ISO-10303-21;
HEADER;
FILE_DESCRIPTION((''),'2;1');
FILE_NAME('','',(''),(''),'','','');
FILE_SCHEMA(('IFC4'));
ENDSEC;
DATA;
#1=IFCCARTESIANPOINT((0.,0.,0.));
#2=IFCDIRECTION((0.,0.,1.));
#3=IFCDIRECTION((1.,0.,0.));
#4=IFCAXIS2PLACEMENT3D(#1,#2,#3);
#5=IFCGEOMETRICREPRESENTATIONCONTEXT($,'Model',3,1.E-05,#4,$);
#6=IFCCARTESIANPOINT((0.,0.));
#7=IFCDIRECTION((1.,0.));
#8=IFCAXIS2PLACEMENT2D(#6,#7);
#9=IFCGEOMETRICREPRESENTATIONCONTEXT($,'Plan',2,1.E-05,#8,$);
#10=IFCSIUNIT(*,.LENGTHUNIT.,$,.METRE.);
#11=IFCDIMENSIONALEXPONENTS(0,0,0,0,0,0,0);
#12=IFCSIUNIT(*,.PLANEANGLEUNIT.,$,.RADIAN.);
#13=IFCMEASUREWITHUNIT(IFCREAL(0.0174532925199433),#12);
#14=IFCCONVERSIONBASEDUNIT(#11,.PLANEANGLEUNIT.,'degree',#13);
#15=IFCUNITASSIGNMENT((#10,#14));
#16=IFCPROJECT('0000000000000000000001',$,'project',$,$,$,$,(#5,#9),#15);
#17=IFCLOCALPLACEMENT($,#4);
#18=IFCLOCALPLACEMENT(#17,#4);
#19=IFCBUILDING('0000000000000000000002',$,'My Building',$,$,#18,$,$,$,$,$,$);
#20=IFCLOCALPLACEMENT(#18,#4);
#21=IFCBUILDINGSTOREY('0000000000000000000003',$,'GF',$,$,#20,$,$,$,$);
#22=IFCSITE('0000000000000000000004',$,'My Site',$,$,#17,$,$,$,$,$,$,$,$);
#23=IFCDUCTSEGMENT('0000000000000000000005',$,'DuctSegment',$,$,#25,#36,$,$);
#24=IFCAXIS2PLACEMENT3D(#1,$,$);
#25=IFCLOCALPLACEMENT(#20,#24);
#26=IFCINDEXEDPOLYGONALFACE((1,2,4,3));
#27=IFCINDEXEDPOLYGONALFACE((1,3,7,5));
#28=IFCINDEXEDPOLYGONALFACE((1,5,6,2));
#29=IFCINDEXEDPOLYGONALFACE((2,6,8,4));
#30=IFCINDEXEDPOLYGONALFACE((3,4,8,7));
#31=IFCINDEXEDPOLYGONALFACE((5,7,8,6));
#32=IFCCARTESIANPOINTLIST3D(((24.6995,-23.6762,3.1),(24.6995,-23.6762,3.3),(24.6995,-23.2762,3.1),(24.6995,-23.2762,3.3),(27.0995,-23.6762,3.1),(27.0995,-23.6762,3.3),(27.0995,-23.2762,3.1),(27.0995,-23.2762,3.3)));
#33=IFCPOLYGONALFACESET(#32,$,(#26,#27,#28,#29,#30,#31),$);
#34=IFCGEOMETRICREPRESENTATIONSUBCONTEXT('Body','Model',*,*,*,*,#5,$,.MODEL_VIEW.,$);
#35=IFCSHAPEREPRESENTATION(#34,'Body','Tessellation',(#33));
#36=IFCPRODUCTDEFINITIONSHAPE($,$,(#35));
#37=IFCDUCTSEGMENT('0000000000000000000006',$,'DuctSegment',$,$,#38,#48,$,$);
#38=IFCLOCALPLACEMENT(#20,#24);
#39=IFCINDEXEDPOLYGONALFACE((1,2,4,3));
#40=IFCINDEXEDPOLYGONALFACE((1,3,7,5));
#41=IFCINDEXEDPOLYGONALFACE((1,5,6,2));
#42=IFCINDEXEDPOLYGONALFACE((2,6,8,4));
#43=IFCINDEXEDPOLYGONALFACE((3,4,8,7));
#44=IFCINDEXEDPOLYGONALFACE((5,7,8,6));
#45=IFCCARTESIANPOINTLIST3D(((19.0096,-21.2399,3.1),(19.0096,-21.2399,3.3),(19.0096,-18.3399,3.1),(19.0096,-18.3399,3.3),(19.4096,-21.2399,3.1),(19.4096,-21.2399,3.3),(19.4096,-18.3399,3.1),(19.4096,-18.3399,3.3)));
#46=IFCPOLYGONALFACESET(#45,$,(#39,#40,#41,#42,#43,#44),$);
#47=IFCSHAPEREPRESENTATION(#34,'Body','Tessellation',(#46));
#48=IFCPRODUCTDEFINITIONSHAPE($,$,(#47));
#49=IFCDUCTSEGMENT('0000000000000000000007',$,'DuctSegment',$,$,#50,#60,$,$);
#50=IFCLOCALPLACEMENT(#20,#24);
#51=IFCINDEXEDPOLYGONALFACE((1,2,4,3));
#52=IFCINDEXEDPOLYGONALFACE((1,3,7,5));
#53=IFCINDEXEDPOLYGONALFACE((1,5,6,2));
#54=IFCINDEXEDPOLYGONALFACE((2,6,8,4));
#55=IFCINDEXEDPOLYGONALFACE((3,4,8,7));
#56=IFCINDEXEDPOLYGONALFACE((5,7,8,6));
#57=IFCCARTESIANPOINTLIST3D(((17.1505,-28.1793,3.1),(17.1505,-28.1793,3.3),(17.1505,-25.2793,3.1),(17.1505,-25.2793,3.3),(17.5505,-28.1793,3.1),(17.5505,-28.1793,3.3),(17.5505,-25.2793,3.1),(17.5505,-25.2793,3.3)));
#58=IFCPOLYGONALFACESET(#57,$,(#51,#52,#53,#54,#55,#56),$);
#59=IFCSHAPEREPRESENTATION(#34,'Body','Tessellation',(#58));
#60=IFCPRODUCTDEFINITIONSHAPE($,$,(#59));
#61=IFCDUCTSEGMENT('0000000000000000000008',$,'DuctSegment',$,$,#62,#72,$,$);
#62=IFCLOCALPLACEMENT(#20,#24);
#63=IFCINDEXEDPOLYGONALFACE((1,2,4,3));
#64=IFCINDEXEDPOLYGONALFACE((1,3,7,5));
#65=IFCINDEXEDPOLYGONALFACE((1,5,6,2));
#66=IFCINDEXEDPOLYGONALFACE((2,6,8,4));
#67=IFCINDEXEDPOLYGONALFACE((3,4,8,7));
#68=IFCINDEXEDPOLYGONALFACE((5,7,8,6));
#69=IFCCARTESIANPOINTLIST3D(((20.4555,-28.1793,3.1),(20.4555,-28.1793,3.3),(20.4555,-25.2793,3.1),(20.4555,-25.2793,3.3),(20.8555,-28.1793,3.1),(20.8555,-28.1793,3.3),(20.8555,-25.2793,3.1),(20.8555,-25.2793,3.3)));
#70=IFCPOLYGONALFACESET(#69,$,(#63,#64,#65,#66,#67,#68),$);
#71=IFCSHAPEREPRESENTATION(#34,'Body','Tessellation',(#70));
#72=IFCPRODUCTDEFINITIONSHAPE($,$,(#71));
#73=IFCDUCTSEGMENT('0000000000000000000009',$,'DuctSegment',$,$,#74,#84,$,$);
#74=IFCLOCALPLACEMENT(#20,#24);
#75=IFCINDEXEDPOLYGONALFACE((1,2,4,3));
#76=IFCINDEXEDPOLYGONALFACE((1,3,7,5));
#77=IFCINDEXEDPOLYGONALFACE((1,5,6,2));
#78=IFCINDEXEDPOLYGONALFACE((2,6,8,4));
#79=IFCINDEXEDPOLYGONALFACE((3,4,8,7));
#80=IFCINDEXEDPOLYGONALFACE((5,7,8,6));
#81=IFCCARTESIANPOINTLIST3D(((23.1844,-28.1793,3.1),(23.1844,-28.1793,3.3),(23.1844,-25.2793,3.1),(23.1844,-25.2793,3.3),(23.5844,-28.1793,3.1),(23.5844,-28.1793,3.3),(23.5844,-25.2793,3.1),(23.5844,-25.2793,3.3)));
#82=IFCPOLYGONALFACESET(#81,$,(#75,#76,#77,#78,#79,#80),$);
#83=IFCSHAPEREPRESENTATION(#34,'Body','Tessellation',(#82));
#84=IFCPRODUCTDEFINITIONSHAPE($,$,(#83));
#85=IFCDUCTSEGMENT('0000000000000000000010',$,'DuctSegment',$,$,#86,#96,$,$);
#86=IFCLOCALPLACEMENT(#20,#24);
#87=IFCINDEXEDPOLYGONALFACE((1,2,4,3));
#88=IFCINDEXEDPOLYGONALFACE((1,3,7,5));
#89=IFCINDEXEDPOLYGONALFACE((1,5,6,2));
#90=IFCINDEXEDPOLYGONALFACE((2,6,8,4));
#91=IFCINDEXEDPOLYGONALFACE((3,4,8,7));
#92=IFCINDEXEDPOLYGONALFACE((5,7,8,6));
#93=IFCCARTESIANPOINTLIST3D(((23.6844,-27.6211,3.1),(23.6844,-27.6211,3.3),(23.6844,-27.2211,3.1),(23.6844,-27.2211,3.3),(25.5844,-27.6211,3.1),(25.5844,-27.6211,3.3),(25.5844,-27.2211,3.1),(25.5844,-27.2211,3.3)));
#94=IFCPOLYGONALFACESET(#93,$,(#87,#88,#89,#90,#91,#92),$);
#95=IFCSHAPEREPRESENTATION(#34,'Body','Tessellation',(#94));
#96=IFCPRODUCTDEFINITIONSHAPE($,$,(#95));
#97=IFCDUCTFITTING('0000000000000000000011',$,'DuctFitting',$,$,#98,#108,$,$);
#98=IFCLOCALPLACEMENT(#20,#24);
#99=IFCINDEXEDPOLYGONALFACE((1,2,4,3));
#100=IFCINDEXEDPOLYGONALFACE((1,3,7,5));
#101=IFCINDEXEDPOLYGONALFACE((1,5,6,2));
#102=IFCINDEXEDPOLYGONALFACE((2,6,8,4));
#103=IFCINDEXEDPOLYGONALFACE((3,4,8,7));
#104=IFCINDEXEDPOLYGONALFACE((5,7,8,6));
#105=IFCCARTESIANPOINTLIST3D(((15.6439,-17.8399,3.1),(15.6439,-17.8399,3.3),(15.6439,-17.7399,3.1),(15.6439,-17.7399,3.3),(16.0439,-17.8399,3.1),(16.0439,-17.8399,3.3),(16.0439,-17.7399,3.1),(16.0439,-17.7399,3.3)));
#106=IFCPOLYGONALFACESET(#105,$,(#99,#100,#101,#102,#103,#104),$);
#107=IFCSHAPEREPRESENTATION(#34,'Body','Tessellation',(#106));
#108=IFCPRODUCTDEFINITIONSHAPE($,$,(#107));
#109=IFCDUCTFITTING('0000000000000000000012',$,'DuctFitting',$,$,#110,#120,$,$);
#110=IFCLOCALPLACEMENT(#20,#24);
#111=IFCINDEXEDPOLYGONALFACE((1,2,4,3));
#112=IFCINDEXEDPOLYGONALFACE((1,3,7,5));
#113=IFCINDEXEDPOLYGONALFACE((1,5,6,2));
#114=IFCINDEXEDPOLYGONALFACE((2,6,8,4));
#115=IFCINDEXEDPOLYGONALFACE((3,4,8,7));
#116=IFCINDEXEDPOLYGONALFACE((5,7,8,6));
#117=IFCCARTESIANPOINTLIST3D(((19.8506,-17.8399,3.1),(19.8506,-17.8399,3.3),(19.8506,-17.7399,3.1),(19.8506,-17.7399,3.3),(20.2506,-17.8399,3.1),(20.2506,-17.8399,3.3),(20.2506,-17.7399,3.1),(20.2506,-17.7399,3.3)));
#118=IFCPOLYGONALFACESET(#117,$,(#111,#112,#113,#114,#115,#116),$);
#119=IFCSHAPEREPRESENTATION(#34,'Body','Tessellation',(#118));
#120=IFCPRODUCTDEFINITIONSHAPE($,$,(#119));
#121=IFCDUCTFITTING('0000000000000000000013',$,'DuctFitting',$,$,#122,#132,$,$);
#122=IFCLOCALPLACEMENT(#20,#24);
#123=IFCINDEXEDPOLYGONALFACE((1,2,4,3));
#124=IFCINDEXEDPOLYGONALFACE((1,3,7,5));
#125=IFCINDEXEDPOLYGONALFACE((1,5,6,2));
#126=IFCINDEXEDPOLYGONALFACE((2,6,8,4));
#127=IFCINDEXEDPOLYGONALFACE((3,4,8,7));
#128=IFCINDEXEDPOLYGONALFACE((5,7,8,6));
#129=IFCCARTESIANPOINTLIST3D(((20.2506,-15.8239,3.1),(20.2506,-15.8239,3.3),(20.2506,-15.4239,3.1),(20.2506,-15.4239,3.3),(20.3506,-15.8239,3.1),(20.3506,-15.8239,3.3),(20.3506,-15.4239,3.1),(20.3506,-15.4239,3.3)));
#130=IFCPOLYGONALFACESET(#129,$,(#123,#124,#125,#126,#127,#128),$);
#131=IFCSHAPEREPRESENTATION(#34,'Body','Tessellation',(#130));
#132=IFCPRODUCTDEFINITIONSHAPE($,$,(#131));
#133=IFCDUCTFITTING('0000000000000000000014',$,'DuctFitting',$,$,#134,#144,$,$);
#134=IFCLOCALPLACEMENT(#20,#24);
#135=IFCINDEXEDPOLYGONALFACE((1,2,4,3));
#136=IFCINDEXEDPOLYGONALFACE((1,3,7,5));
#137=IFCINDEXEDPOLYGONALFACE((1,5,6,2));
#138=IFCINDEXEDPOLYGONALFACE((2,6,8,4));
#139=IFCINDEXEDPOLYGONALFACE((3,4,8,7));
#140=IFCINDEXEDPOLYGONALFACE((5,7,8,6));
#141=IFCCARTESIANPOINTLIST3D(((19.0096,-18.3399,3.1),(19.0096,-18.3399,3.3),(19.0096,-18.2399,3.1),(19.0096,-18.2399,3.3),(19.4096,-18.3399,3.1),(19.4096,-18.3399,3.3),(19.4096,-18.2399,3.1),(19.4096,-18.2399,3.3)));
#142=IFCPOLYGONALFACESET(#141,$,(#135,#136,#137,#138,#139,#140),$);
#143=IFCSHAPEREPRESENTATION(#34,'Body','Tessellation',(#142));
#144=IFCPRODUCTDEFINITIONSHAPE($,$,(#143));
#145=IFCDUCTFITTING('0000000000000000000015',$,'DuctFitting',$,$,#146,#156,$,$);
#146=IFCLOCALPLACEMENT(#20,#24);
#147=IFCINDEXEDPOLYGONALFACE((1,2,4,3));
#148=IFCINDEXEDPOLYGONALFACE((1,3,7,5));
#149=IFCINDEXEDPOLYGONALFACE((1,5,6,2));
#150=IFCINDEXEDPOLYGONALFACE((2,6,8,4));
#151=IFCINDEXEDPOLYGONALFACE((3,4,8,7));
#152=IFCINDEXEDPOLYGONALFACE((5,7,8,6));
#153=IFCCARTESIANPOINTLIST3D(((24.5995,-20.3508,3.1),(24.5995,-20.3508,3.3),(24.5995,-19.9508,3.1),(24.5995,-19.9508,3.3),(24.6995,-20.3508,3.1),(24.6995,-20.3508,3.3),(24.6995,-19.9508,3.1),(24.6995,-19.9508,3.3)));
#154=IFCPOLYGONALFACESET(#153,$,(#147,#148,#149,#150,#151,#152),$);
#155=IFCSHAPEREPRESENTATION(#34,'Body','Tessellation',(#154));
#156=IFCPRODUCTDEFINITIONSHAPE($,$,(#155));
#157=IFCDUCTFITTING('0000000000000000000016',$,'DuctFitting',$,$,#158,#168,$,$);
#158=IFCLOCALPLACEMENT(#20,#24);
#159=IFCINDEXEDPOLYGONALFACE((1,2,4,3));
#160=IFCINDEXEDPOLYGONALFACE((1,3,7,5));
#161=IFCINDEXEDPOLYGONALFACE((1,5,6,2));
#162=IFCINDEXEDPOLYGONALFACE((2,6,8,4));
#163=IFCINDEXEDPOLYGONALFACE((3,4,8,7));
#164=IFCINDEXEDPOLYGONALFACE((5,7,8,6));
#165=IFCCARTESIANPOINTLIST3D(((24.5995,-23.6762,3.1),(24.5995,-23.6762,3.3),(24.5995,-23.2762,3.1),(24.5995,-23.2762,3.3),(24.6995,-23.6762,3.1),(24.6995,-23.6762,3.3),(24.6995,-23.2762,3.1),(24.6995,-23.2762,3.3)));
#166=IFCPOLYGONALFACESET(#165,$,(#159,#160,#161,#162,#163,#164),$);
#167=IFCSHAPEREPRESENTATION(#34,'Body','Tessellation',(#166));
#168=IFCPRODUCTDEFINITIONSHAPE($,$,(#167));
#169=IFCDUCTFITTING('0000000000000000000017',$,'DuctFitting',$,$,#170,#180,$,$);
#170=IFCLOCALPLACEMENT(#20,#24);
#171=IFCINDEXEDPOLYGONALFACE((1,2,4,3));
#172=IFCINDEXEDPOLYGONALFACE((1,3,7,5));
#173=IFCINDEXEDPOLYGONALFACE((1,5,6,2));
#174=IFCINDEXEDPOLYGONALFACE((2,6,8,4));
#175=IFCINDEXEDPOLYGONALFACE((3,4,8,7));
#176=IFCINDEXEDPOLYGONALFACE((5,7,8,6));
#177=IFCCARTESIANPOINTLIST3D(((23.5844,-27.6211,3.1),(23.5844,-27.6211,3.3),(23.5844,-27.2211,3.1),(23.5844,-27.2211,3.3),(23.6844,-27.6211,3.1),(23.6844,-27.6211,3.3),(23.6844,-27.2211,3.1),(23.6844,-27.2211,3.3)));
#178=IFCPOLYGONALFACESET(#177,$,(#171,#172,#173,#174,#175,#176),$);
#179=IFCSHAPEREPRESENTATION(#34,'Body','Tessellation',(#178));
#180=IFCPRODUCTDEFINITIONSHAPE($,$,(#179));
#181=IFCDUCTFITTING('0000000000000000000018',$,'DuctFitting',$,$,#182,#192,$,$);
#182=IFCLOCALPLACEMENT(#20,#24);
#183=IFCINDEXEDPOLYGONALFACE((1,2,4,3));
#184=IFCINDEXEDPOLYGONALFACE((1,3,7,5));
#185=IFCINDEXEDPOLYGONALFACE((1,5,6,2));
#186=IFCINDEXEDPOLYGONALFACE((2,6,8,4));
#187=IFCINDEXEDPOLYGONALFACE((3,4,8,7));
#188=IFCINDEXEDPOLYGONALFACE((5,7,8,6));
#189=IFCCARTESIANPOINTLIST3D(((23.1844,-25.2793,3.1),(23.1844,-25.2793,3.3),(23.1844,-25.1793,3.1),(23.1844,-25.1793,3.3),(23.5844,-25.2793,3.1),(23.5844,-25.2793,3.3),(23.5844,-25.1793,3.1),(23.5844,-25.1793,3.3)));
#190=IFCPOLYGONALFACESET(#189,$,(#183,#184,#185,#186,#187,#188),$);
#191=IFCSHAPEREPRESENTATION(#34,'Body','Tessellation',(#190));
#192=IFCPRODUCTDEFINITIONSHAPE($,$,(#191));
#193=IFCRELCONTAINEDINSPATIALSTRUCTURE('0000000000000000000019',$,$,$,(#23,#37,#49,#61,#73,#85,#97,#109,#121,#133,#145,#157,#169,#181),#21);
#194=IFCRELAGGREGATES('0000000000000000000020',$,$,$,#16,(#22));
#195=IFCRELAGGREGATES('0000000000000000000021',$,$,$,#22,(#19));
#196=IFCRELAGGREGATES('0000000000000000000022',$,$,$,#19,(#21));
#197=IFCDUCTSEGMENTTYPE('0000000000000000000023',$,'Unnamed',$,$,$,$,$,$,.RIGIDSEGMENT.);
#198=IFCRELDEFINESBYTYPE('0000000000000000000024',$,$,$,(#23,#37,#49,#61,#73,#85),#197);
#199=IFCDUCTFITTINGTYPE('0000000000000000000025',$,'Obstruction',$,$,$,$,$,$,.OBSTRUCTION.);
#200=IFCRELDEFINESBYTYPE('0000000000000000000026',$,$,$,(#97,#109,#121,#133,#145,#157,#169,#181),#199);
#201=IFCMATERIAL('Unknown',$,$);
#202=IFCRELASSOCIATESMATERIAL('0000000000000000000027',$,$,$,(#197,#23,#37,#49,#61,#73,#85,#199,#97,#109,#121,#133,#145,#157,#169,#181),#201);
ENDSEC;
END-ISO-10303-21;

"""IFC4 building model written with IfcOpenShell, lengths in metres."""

from ifc_helpers import new_model, entity, si_unit, converted_unit, frame, origin_with_axes, origin_2d_with_axis, place, context, subcontext, project, spatial, rectangle, extrude, material, material_profile, profile_set, profile_usage, type_object, element, save


model = new_model("IFC4")

# Units and contexts
model_context = context("Model", 3, precision=1e-05, world=origin_with_axes())
plan_context = context("Plan", 2, precision=1e-05, world=origin_2d_with_axis())
body_context_1 = subcontext(model_context, "Body", "Model", "MODEL_VIEW")
ifc_project = project(units=[si_unit("LENGTHUNIT", "METRE"), converted_unit("PLANEANGLEUNIT", "degree", entity("IfcReal", 0.0174532925199433), si_unit("PLANEANGLEUNIT", "RADIAN"), dimensions=[0, 0, 0, 0, 0, 0, 0])], contexts=[model_context, plan_context])

# Site, building, storey
site_placement = place(None, origin_with_axes())
site = spatial("IfcSite", under=ifc_project, at=site_placement, Name="My Site")
building_placement = place(site_placement, origin_with_axes())
building = spatial("IfcBuilding", under=site, at=building_placement, Name="My Building")
storey_placement = place(building_placement, origin_with_axes())
storey = spatial("IfcBuildingStorey", under=building, at=storey_placement, Name="GF")

# Shared definitions
ifc_material = material(Name="Unknown")

# Duct segments
ifc_material_profile_1 = material_profile(ifc_material, rectangle(XDim=0.4, YDim=0.2))
ifc_profile_set_1 = profile_set([ifc_material_profile_1])
duct_segment_type = type_object("IfcDuctSegmentType", Name="Unnamed", PredefinedType="RIGIDSEGMENT", material=ifc_profile_set_1)
ifc_profile_usage_1 = profile_usage(ifc_profile_set_1, cardinal=5)
duct_segment_1_placement = place(storey_placement, frame((24.6995, -23.4762, 3.2), z_axis=(1.0, -0.000001, 0.000001), x_axis=(0.000001, 1.0, 0.0)))
element("IfcDuctSegment", 1, at=duct_segment_1_placement, inside=storey, type_object=duct_segment_type, material=ifc_profile_usage_1, Name="DuctSegment", context=body_context_1, shape_type="SweptSolid", body=[
    extrude(rectangle(XDim=0.4, YDim=0.2), origin_with_axes(), (0.0, 0.0, 1.0), 2.4),
])
ifc_profile_usage_2 = profile_usage(ifc_profile_set_1, cardinal=5)
duct_segment_2_placement = place(storey_placement, frame((19.2096, -18.3399, 3.2), z_axis=(0.0, -1.0, -0.000001), x_axis=(1.0, 0.0, 0.0)))
element("IfcDuctSegment", 2, at=duct_segment_2_placement, inside=storey, type_object=duct_segment_type, material=ifc_profile_usage_2, Name="DuctSegment", context=body_context_1, shape_type="SweptSolid", body=[
    extrude(rectangle(XDim=0.4, YDim=0.2), origin_with_axes(), (0.0, 0.0, 1.0), 2.9),
])
ifc_profile_usage_3 = profile_usage(ifc_profile_set_1, cardinal=5)
duct_segment_3_placement = place(storey_placement, frame((17.3505, -25.2793, 3.2), z_axis=(0.0, -1.0, 0.0), x_axis=(1.0, 0.0, 0.0)))
element("IfcDuctSegment", 3, at=duct_segment_3_placement, inside=storey, type_object=duct_segment_type, material=ifc_profile_usage_3, Name="DuctSegment", context=body_context_1, shape_type="SweptSolid", body=[
    extrude(rectangle(XDim=0.4, YDim=0.2), origin_with_axes(), (0.0, 0.0, 1.0), 2.9),
])
ifc_profile_usage_4 = profile_usage(ifc_profile_set_1, cardinal=5)
duct_segment_4_placement = place(storey_placement, frame((20.6555, -25.2793, 3.2), z_axis=(0.0, -1.0, 0.0), x_axis=(1.0, 0.0, 0.0)))
element("IfcDuctSegment", 4, at=duct_segment_4_placement, inside=storey, type_object=duct_segment_type, material=ifc_profile_usage_4, Name="DuctSegment", context=body_context_1, shape_type="SweptSolid", body=[
    extrude(rectangle(XDim=0.4, YDim=0.2), origin_with_axes(), (0.0, 0.0, 1.0), 2.9),
])
ifc_profile_usage_5 = profile_usage(ifc_profile_set_1, cardinal=5)
duct_segment_5_placement = place(storey_placement, frame((23.3844, -25.2793, 3.2), z_axis=(0.0, -1.0, 0.0), x_axis=(1.0, 0.0, 0.0)))
element("IfcDuctSegment", 5, at=duct_segment_5_placement, inside=storey, type_object=duct_segment_type, material=ifc_profile_usage_5, Name="DuctSegment", context=body_context_1, shape_type="SweptSolid", body=[
    extrude(rectangle(XDim=0.4, YDim=0.2), origin_with_axes(), (0.0, 0.0, 1.0), 2.9),
])
ifc_profile_usage_6 = profile_usage(ifc_profile_set_1, cardinal=5)
duct_segment_6_placement = place(storey_placement, frame((23.6844, -27.4211, 3.2), z_axis=(1.0, 0.0, 0.0), x_axis=(0.0, 1.0, 0.0)))
element("IfcDuctSegment", 6, at=duct_segment_6_placement, inside=storey, type_object=duct_segment_type, material=ifc_profile_usage_6, Name="DuctSegment", context=body_context_1, shape_type="SweptSolid", body=[
    extrude(rectangle(XDim=0.4, YDim=0.2), origin_with_axes(), (0.0, 0.0, 1.0), 1.9),
])

# Duct fittings
ifc_material_profile_2 = material_profile(ifc_material, rectangle(XDim=0.4, YDim=0.2))
ifc_profile_set_2 = profile_set([ifc_material_profile_2])
ifc_profile_usage_7 = profile_usage(ifc_profile_set_2, cardinal=5)
duct_fitting_type = type_object("IfcDuctFittingType", Name="Obstruction", PredefinedType="OBSTRUCTION", material=ifc_profile_set_2)
duct_fitting_1_placement = place(storey_placement, frame((15.8439, -17.8399, 3.2), z_axis=(0.0, 1.0, -0.000004), x_axis=(-1.0, 0.0, 0.0)))
element("IfcDuctFitting", 7, at=duct_fitting_1_placement, inside=storey, type_object=duct_fitting_type, material=ifc_profile_usage_7, Name="DuctFitting", context=body_context_1, shape_type="SweptSolid", body=[
    extrude(rectangle(XDim=0.4, YDim=0.2), origin_with_axes(), (0.0, 0.0, 1.0), 0.1),
])
ifc_profile_usage_8 = profile_usage(ifc_profile_set_2, cardinal=5)
duct_fitting_2_placement = place(storey_placement, frame((20.0506, -17.8399, 3.2), z_axis=(0.0, 1.0, -0.000003), x_axis=(-1.0, 0.0, 0.0)))
element("IfcDuctFitting", 8, at=duct_fitting_2_placement, inside=storey, type_object=duct_fitting_type, material=ifc_profile_usage_8, Name="DuctFitting", context=body_context_1, shape_type="SweptSolid", body=[
    extrude(rectangle(XDim=0.4, YDim=0.2), origin_with_axes(), (0.0, 0.0, 1.0), 0.1),
])
ifc_profile_usage_9 = profile_usage(ifc_profile_set_2, cardinal=5)
duct_fitting_3_placement = place(storey_placement, frame((20.2506, -15.6239, 3.2), z_axis=(1.0, -0.000001, 0.000001), x_axis=(0.000001, 1.0, 0.0)))
element("IfcDuctFitting", 9, at=duct_fitting_3_placement, inside=storey, type_object=duct_fitting_type, material=ifc_profile_usage_9, Name="DuctFitting", context=body_context_1, shape_type="SweptSolid", body=[
    extrude(rectangle(XDim=0.4, YDim=0.2), origin_with_axes(), (0.0, 0.0, 1.0), 0.1),
])
ifc_profile_usage_10 = profile_usage(ifc_profile_set_2, cardinal=5)
duct_fitting_4_placement = place(storey_placement, frame((19.2096, -18.2399, 3.2), z_axis=(0.0, -1.0, -0.000001), x_axis=(1.0, 0.0, 0.0)))
element("IfcDuctFitting", 10, at=duct_fitting_4_placement, inside=storey, type_object=duct_fitting_type, material=ifc_profile_usage_10, Name="DuctFitting", context=body_context_1, shape_type="SweptSolid", body=[
    extrude(rectangle(XDim=0.4, YDim=0.2), origin_with_axes(), (0.0, 0.0, 1.0), 0.1),
])
ifc_profile_usage_11 = profile_usage(ifc_profile_set_2, cardinal=5)
duct_fitting_5_placement = place(storey_placement, frame((24.5995, -20.1508, 3.2), z_axis=(1.0, -0.000001, 0.000001), x_axis=(0.000001, 1.0, 0.0)))
element("IfcDuctFitting", 11, at=duct_fitting_5_placement, inside=storey, type_object=duct_fitting_type, material=ifc_profile_usage_11, Name="DuctFitting", context=body_context_1, shape_type="SweptSolid", body=[
    extrude(rectangle(XDim=0.4, YDim=0.2), origin_with_axes(), (0.0, 0.0, 1.0), 0.1),
])
ifc_profile_usage_12 = profile_usage(ifc_profile_set_2, cardinal=5)
duct_fitting_6_placement = place(storey_placement, frame((24.5995, -23.4762, 3.2), z_axis=(1.0, -0.000001, 0.000001), x_axis=(0.000001, 1.0, 0.0)))
element("IfcDuctFitting", 12, at=duct_fitting_6_placement, inside=storey, type_object=duct_fitting_type, material=ifc_profile_usage_12, Name="DuctFitting", context=body_context_1, shape_type="SweptSolid", body=[
    extrude(rectangle(XDim=0.4, YDim=0.2), origin_with_axes(), (0.0, 0.0, 1.0), 0.1),
])
ifc_profile_usage_13 = profile_usage(ifc_profile_set_2, cardinal=5)
duct_fitting_7_placement = place(storey_placement, frame((23.5844, -27.4211, 3.2), z_axis=(1.0, 0.0, 0.0), x_axis=(0.0, 1.0, 0.0)))
element("IfcDuctFitting", 13, at=duct_fitting_7_placement, inside=storey, type_object=duct_fitting_type, material=ifc_profile_usage_13, Name="DuctFitting", context=body_context_1, shape_type="SweptSolid", body=[
    extrude(rectangle(XDim=0.4, YDim=0.2), origin_with_axes(), (0.0, 0.0, 1.0), 0.1),
])
ifc_profile_usage_14 = profile_usage(ifc_profile_set_2, cardinal=5)
duct_fitting_8_placement = place(storey_placement, frame((23.3844, -25.1793, 3.2), z_axis=(0.0, -1.0, 0.0), x_axis=(1.0, 0.0, 0.0)))
element("IfcDuctFitting", 14, at=duct_fitting_8_placement, inside=storey, type_object=duct_fitting_type, material=ifc_profile_usage_14, Name="DuctFitting", context=body_context_1, shape_type="SweptSolid", body=[
    extrude(rectangle(XDim=0.4, YDim=0.2), origin_with_axes(), (0.0, 0.0, 1.0), 0.1),
])

save(model, "model.ifc")
